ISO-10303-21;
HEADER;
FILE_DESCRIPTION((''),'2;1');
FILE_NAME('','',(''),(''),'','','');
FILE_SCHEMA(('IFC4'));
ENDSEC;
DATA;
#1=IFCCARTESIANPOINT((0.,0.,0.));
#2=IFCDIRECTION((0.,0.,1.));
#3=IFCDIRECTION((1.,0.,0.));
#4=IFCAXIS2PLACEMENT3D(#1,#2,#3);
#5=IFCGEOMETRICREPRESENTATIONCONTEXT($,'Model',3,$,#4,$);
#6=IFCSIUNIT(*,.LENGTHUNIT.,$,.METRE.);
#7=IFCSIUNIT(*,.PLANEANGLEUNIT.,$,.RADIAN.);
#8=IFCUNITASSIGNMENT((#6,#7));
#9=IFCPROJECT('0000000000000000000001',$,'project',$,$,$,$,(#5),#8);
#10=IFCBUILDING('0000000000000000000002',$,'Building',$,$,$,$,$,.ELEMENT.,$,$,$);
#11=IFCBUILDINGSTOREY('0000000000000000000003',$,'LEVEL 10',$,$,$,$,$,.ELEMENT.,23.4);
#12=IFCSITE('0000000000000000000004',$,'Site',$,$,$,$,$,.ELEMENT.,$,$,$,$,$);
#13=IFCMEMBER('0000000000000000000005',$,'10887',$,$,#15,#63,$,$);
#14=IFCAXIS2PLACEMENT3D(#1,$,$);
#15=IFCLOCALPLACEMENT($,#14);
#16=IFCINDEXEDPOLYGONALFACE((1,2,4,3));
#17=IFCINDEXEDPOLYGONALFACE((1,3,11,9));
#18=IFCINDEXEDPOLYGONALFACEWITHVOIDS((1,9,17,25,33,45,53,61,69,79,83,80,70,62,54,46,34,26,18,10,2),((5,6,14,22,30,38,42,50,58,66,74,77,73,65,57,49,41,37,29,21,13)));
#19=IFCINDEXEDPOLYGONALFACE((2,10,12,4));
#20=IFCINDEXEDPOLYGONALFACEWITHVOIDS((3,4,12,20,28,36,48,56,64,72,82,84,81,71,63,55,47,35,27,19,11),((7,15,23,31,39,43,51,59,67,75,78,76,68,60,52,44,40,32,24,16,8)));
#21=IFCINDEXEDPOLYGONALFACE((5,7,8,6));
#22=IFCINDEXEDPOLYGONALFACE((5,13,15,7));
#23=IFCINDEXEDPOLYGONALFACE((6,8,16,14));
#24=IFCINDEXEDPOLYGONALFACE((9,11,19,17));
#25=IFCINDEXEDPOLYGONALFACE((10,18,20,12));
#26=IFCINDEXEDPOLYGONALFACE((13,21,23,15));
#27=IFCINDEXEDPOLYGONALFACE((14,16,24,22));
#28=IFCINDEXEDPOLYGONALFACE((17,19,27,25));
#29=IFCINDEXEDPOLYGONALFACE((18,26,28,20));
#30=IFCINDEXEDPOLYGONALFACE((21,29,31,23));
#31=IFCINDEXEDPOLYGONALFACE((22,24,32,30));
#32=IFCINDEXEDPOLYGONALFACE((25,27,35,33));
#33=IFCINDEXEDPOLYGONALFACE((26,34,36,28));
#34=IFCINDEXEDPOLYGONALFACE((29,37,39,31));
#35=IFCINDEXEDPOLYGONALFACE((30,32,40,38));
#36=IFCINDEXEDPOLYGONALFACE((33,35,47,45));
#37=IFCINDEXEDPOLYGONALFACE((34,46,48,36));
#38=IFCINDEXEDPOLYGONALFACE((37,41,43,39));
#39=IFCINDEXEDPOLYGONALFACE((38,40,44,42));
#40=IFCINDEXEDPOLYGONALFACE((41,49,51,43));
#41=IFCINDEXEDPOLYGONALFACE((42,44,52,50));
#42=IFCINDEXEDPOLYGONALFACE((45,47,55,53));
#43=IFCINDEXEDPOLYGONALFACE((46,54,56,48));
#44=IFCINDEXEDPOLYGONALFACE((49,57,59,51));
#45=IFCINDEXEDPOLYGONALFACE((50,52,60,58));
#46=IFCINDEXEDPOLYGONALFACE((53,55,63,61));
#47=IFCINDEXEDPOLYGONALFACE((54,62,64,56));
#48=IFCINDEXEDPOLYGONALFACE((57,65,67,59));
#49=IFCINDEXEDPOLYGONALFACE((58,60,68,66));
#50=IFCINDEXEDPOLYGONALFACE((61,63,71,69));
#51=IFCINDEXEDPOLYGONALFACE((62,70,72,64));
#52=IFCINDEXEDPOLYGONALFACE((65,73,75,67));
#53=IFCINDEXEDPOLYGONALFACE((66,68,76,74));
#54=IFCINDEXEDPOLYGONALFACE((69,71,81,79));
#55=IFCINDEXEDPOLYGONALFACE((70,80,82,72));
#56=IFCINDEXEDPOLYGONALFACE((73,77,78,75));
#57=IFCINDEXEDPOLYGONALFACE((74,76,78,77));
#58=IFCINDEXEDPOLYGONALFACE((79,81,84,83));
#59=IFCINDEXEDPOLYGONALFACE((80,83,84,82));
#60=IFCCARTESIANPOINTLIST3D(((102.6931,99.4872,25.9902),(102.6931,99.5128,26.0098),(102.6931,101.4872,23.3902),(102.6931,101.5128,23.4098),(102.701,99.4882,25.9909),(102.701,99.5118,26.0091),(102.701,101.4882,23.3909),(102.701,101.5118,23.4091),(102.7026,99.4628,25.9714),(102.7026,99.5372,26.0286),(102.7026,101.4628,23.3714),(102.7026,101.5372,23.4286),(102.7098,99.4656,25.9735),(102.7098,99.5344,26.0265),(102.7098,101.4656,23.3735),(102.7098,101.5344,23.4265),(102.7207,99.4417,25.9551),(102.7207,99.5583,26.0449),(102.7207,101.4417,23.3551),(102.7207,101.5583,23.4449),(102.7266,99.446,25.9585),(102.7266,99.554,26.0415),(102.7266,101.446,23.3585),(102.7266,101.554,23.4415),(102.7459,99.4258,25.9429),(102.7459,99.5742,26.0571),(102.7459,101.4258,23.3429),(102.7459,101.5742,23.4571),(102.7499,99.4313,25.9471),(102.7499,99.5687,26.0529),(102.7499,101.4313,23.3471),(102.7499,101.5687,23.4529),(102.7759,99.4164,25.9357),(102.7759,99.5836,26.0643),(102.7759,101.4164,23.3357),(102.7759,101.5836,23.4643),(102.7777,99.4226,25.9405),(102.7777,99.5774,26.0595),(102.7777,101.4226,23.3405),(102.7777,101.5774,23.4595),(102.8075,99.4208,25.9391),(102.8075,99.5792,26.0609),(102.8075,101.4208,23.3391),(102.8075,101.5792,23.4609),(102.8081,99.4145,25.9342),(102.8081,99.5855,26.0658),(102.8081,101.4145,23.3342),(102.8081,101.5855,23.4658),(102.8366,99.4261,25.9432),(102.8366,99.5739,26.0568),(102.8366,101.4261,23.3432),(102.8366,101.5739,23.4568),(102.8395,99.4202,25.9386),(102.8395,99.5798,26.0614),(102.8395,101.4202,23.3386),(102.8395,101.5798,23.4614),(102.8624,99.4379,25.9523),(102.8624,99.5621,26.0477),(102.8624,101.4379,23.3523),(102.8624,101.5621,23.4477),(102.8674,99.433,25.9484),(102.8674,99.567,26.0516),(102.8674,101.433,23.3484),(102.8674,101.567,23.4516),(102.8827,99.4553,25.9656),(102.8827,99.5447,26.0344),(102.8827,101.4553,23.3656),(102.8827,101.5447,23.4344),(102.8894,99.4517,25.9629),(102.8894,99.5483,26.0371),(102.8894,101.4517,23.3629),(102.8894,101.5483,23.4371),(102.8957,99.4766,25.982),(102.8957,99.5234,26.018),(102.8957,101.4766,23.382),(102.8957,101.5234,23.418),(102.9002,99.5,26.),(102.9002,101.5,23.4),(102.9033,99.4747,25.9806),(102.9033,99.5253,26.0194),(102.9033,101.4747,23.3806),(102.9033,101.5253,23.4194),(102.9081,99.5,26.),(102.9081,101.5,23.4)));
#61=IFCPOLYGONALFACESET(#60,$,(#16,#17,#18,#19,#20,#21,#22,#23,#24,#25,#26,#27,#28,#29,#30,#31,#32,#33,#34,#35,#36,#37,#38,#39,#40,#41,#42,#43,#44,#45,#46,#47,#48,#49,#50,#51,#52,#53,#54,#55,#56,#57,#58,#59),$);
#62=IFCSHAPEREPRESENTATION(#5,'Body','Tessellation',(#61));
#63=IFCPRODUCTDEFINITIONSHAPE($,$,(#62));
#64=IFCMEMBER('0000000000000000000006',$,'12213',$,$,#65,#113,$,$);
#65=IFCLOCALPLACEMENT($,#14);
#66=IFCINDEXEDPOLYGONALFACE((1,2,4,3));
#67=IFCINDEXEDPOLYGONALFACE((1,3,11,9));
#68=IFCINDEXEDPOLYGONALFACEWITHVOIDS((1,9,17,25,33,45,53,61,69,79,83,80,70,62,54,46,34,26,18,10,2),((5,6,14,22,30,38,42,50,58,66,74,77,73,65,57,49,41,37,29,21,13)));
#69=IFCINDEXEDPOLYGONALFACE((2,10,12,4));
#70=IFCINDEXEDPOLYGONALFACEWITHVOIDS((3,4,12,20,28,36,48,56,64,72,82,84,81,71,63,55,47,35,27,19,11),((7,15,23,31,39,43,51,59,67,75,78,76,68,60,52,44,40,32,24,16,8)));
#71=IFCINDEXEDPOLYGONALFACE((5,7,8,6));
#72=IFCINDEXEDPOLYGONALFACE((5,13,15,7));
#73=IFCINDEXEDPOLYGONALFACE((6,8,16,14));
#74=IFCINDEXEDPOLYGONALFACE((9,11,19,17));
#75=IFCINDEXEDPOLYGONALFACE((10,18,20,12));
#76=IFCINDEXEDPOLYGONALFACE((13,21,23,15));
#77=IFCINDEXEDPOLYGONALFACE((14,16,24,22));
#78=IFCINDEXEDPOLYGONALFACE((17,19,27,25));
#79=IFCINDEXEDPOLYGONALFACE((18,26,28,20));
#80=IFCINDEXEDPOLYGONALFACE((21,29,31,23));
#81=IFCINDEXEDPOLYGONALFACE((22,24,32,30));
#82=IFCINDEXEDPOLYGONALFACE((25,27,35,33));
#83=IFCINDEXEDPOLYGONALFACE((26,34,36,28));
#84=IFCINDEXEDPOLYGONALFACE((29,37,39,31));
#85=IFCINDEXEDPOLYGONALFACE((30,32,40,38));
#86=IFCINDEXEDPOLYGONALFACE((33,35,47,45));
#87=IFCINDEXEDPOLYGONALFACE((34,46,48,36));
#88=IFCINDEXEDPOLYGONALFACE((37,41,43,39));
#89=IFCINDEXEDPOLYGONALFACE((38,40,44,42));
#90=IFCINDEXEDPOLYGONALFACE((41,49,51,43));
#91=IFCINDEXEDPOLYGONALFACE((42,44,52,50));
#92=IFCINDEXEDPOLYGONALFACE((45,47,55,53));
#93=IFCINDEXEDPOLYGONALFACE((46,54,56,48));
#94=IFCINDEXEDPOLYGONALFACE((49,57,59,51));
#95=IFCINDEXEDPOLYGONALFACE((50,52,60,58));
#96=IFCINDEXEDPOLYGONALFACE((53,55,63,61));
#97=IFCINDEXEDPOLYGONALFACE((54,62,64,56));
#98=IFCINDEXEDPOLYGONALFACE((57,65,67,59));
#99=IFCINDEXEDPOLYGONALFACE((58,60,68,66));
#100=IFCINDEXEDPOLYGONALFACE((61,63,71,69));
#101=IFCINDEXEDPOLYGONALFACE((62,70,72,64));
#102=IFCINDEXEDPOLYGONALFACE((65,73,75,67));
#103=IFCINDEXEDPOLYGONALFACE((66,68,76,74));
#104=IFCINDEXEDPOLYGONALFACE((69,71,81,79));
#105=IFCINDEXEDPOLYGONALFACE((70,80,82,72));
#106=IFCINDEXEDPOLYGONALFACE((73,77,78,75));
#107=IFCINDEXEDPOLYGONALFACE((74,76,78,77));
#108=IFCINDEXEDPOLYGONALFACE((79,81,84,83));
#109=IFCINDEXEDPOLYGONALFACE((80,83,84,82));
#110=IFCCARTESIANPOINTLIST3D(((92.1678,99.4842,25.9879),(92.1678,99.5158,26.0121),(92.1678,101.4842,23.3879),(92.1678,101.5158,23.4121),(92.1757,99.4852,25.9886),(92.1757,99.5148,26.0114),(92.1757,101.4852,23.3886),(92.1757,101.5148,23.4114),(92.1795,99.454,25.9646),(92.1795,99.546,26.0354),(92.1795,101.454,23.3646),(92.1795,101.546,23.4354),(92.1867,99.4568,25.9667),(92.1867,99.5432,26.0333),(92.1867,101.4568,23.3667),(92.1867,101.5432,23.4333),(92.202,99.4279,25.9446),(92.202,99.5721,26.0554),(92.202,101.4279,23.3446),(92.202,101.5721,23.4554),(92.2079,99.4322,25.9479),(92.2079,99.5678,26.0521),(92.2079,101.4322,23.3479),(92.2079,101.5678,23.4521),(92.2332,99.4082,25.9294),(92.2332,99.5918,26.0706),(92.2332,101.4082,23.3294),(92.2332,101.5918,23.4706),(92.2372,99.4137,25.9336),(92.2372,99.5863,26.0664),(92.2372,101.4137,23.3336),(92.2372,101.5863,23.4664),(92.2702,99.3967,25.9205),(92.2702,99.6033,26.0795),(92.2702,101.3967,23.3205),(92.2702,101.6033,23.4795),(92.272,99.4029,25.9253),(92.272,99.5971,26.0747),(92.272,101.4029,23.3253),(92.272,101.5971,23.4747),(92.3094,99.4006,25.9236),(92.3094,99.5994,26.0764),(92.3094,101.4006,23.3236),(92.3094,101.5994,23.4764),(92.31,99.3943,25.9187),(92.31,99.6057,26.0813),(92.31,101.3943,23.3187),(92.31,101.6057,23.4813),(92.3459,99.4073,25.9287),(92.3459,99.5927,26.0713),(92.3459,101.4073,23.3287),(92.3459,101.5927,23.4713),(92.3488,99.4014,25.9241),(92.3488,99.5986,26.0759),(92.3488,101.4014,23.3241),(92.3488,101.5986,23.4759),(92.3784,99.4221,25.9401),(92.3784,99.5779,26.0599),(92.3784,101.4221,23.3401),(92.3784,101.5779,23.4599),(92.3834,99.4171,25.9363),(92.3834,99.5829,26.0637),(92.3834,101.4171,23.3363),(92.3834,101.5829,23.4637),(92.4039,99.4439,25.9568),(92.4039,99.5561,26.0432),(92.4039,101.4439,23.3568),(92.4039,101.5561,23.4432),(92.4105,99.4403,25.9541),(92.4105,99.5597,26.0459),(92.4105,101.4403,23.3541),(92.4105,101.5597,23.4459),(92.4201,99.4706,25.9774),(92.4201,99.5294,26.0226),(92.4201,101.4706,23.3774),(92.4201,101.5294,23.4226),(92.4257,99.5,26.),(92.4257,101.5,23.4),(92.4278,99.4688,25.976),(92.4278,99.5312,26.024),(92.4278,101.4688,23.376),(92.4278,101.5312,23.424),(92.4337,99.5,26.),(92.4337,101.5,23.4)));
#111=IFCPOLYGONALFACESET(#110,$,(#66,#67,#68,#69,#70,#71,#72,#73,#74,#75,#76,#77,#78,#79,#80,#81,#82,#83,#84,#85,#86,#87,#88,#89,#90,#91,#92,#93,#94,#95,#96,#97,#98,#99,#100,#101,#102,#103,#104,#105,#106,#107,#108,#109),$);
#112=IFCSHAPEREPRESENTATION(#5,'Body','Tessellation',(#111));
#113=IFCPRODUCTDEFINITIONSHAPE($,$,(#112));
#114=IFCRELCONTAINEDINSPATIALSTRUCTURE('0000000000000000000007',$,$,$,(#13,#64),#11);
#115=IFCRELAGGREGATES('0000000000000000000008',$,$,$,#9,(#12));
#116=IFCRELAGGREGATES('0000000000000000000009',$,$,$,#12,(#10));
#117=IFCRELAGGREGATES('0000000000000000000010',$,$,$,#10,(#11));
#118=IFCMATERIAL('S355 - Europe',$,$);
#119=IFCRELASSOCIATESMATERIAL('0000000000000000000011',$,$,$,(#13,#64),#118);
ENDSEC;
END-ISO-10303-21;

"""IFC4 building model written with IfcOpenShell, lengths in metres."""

from ifc_helpers import new_model, si_unit, frame, origin_with_axes, origin_2d_with_axis, place, context, project, spatial, hollow_circle, extrude, material, material_profile, profile_set, profile_usage, element, save


model = new_model("IFC4")

# Units and contexts
model_context = context("Model", 3, world=origin_with_axes())
ifc_project = project(units=[si_unit("LENGTHUNIT", "METRE"), si_unit("PLANEANGLEUNIT", "RADIAN")], contexts=[model_context])

# Site, building, storey
site = spatial("IfcSite", under=ifc_project, Name="Site", CompositionType="ELEMENT")
building = spatial("IfcBuilding", under=site, Name="Building", CompositionType="ELEMENT")
storey = spatial("IfcBuildingStorey", under=building, Name="LEVEL 10", CompositionType="ELEMENT", Elevation=23.4)

# Shared definitions
ifc_material = material(Name="S355 - Europe")

# Members
ifc_material_profile_1 = material_profile(ifc_material, hollow_circle(Radius=0.1081, WallThickness=0.008, at=origin_2d_with_axis()))
ifc_profile_set_1 = profile_set([ifc_material_profile_1])
ifc_profile_usage_1 = profile_usage(ifc_profile_set_1, cardinal=10)
member_1_placement = place(None, frame((102.8, 101.5, 23.4), z_axis=(0.0, -0.609711, 0.792624), x_axis=(1.0, 0.0, 0.0)))
element("IfcMember", 1, at=member_1_placement, inside=storey, material=ifc_profile_usage_1, Name="10887", context=model_context, shape_type="SweptSolid", body=[
    extrude(hollow_circle(Radius=0.1081, WallThickness=0.008, at=origin_2d_with_axis()), origin_with_axes(), (0.0, 0.0, 1.0), 3.2802),
])
ifc_material_profile_2 = material_profile(ifc_material, hollow_circle(Radius=0.1337, WallThickness=0.008, at=origin_2d_with_axis()))
ifc_profile_set_2 = profile_set([ifc_material_profile_2])
ifc_profile_usage_2 = profile_usage(ifc_profile_set_2, cardinal=10)
member_2_placement = place(None, frame((92.3, 101.5, 23.4), z_axis=(0.0, -0.609711, 0.792624), x_axis=(1.0, 0.0, 0.0)))
element("IfcMember", 2, at=member_2_placement, inside=storey, material=ifc_profile_usage_2, Name="12213", context=model_context, shape_type="SweptSolid", body=[
    extrude(hollow_circle(Radius=0.1337, WallThickness=0.008, at=origin_2d_with_axis()), origin_with_axes(), (0.0, 0.0, 1.0), 3.2802),
])

save(model, "model.ifc")
